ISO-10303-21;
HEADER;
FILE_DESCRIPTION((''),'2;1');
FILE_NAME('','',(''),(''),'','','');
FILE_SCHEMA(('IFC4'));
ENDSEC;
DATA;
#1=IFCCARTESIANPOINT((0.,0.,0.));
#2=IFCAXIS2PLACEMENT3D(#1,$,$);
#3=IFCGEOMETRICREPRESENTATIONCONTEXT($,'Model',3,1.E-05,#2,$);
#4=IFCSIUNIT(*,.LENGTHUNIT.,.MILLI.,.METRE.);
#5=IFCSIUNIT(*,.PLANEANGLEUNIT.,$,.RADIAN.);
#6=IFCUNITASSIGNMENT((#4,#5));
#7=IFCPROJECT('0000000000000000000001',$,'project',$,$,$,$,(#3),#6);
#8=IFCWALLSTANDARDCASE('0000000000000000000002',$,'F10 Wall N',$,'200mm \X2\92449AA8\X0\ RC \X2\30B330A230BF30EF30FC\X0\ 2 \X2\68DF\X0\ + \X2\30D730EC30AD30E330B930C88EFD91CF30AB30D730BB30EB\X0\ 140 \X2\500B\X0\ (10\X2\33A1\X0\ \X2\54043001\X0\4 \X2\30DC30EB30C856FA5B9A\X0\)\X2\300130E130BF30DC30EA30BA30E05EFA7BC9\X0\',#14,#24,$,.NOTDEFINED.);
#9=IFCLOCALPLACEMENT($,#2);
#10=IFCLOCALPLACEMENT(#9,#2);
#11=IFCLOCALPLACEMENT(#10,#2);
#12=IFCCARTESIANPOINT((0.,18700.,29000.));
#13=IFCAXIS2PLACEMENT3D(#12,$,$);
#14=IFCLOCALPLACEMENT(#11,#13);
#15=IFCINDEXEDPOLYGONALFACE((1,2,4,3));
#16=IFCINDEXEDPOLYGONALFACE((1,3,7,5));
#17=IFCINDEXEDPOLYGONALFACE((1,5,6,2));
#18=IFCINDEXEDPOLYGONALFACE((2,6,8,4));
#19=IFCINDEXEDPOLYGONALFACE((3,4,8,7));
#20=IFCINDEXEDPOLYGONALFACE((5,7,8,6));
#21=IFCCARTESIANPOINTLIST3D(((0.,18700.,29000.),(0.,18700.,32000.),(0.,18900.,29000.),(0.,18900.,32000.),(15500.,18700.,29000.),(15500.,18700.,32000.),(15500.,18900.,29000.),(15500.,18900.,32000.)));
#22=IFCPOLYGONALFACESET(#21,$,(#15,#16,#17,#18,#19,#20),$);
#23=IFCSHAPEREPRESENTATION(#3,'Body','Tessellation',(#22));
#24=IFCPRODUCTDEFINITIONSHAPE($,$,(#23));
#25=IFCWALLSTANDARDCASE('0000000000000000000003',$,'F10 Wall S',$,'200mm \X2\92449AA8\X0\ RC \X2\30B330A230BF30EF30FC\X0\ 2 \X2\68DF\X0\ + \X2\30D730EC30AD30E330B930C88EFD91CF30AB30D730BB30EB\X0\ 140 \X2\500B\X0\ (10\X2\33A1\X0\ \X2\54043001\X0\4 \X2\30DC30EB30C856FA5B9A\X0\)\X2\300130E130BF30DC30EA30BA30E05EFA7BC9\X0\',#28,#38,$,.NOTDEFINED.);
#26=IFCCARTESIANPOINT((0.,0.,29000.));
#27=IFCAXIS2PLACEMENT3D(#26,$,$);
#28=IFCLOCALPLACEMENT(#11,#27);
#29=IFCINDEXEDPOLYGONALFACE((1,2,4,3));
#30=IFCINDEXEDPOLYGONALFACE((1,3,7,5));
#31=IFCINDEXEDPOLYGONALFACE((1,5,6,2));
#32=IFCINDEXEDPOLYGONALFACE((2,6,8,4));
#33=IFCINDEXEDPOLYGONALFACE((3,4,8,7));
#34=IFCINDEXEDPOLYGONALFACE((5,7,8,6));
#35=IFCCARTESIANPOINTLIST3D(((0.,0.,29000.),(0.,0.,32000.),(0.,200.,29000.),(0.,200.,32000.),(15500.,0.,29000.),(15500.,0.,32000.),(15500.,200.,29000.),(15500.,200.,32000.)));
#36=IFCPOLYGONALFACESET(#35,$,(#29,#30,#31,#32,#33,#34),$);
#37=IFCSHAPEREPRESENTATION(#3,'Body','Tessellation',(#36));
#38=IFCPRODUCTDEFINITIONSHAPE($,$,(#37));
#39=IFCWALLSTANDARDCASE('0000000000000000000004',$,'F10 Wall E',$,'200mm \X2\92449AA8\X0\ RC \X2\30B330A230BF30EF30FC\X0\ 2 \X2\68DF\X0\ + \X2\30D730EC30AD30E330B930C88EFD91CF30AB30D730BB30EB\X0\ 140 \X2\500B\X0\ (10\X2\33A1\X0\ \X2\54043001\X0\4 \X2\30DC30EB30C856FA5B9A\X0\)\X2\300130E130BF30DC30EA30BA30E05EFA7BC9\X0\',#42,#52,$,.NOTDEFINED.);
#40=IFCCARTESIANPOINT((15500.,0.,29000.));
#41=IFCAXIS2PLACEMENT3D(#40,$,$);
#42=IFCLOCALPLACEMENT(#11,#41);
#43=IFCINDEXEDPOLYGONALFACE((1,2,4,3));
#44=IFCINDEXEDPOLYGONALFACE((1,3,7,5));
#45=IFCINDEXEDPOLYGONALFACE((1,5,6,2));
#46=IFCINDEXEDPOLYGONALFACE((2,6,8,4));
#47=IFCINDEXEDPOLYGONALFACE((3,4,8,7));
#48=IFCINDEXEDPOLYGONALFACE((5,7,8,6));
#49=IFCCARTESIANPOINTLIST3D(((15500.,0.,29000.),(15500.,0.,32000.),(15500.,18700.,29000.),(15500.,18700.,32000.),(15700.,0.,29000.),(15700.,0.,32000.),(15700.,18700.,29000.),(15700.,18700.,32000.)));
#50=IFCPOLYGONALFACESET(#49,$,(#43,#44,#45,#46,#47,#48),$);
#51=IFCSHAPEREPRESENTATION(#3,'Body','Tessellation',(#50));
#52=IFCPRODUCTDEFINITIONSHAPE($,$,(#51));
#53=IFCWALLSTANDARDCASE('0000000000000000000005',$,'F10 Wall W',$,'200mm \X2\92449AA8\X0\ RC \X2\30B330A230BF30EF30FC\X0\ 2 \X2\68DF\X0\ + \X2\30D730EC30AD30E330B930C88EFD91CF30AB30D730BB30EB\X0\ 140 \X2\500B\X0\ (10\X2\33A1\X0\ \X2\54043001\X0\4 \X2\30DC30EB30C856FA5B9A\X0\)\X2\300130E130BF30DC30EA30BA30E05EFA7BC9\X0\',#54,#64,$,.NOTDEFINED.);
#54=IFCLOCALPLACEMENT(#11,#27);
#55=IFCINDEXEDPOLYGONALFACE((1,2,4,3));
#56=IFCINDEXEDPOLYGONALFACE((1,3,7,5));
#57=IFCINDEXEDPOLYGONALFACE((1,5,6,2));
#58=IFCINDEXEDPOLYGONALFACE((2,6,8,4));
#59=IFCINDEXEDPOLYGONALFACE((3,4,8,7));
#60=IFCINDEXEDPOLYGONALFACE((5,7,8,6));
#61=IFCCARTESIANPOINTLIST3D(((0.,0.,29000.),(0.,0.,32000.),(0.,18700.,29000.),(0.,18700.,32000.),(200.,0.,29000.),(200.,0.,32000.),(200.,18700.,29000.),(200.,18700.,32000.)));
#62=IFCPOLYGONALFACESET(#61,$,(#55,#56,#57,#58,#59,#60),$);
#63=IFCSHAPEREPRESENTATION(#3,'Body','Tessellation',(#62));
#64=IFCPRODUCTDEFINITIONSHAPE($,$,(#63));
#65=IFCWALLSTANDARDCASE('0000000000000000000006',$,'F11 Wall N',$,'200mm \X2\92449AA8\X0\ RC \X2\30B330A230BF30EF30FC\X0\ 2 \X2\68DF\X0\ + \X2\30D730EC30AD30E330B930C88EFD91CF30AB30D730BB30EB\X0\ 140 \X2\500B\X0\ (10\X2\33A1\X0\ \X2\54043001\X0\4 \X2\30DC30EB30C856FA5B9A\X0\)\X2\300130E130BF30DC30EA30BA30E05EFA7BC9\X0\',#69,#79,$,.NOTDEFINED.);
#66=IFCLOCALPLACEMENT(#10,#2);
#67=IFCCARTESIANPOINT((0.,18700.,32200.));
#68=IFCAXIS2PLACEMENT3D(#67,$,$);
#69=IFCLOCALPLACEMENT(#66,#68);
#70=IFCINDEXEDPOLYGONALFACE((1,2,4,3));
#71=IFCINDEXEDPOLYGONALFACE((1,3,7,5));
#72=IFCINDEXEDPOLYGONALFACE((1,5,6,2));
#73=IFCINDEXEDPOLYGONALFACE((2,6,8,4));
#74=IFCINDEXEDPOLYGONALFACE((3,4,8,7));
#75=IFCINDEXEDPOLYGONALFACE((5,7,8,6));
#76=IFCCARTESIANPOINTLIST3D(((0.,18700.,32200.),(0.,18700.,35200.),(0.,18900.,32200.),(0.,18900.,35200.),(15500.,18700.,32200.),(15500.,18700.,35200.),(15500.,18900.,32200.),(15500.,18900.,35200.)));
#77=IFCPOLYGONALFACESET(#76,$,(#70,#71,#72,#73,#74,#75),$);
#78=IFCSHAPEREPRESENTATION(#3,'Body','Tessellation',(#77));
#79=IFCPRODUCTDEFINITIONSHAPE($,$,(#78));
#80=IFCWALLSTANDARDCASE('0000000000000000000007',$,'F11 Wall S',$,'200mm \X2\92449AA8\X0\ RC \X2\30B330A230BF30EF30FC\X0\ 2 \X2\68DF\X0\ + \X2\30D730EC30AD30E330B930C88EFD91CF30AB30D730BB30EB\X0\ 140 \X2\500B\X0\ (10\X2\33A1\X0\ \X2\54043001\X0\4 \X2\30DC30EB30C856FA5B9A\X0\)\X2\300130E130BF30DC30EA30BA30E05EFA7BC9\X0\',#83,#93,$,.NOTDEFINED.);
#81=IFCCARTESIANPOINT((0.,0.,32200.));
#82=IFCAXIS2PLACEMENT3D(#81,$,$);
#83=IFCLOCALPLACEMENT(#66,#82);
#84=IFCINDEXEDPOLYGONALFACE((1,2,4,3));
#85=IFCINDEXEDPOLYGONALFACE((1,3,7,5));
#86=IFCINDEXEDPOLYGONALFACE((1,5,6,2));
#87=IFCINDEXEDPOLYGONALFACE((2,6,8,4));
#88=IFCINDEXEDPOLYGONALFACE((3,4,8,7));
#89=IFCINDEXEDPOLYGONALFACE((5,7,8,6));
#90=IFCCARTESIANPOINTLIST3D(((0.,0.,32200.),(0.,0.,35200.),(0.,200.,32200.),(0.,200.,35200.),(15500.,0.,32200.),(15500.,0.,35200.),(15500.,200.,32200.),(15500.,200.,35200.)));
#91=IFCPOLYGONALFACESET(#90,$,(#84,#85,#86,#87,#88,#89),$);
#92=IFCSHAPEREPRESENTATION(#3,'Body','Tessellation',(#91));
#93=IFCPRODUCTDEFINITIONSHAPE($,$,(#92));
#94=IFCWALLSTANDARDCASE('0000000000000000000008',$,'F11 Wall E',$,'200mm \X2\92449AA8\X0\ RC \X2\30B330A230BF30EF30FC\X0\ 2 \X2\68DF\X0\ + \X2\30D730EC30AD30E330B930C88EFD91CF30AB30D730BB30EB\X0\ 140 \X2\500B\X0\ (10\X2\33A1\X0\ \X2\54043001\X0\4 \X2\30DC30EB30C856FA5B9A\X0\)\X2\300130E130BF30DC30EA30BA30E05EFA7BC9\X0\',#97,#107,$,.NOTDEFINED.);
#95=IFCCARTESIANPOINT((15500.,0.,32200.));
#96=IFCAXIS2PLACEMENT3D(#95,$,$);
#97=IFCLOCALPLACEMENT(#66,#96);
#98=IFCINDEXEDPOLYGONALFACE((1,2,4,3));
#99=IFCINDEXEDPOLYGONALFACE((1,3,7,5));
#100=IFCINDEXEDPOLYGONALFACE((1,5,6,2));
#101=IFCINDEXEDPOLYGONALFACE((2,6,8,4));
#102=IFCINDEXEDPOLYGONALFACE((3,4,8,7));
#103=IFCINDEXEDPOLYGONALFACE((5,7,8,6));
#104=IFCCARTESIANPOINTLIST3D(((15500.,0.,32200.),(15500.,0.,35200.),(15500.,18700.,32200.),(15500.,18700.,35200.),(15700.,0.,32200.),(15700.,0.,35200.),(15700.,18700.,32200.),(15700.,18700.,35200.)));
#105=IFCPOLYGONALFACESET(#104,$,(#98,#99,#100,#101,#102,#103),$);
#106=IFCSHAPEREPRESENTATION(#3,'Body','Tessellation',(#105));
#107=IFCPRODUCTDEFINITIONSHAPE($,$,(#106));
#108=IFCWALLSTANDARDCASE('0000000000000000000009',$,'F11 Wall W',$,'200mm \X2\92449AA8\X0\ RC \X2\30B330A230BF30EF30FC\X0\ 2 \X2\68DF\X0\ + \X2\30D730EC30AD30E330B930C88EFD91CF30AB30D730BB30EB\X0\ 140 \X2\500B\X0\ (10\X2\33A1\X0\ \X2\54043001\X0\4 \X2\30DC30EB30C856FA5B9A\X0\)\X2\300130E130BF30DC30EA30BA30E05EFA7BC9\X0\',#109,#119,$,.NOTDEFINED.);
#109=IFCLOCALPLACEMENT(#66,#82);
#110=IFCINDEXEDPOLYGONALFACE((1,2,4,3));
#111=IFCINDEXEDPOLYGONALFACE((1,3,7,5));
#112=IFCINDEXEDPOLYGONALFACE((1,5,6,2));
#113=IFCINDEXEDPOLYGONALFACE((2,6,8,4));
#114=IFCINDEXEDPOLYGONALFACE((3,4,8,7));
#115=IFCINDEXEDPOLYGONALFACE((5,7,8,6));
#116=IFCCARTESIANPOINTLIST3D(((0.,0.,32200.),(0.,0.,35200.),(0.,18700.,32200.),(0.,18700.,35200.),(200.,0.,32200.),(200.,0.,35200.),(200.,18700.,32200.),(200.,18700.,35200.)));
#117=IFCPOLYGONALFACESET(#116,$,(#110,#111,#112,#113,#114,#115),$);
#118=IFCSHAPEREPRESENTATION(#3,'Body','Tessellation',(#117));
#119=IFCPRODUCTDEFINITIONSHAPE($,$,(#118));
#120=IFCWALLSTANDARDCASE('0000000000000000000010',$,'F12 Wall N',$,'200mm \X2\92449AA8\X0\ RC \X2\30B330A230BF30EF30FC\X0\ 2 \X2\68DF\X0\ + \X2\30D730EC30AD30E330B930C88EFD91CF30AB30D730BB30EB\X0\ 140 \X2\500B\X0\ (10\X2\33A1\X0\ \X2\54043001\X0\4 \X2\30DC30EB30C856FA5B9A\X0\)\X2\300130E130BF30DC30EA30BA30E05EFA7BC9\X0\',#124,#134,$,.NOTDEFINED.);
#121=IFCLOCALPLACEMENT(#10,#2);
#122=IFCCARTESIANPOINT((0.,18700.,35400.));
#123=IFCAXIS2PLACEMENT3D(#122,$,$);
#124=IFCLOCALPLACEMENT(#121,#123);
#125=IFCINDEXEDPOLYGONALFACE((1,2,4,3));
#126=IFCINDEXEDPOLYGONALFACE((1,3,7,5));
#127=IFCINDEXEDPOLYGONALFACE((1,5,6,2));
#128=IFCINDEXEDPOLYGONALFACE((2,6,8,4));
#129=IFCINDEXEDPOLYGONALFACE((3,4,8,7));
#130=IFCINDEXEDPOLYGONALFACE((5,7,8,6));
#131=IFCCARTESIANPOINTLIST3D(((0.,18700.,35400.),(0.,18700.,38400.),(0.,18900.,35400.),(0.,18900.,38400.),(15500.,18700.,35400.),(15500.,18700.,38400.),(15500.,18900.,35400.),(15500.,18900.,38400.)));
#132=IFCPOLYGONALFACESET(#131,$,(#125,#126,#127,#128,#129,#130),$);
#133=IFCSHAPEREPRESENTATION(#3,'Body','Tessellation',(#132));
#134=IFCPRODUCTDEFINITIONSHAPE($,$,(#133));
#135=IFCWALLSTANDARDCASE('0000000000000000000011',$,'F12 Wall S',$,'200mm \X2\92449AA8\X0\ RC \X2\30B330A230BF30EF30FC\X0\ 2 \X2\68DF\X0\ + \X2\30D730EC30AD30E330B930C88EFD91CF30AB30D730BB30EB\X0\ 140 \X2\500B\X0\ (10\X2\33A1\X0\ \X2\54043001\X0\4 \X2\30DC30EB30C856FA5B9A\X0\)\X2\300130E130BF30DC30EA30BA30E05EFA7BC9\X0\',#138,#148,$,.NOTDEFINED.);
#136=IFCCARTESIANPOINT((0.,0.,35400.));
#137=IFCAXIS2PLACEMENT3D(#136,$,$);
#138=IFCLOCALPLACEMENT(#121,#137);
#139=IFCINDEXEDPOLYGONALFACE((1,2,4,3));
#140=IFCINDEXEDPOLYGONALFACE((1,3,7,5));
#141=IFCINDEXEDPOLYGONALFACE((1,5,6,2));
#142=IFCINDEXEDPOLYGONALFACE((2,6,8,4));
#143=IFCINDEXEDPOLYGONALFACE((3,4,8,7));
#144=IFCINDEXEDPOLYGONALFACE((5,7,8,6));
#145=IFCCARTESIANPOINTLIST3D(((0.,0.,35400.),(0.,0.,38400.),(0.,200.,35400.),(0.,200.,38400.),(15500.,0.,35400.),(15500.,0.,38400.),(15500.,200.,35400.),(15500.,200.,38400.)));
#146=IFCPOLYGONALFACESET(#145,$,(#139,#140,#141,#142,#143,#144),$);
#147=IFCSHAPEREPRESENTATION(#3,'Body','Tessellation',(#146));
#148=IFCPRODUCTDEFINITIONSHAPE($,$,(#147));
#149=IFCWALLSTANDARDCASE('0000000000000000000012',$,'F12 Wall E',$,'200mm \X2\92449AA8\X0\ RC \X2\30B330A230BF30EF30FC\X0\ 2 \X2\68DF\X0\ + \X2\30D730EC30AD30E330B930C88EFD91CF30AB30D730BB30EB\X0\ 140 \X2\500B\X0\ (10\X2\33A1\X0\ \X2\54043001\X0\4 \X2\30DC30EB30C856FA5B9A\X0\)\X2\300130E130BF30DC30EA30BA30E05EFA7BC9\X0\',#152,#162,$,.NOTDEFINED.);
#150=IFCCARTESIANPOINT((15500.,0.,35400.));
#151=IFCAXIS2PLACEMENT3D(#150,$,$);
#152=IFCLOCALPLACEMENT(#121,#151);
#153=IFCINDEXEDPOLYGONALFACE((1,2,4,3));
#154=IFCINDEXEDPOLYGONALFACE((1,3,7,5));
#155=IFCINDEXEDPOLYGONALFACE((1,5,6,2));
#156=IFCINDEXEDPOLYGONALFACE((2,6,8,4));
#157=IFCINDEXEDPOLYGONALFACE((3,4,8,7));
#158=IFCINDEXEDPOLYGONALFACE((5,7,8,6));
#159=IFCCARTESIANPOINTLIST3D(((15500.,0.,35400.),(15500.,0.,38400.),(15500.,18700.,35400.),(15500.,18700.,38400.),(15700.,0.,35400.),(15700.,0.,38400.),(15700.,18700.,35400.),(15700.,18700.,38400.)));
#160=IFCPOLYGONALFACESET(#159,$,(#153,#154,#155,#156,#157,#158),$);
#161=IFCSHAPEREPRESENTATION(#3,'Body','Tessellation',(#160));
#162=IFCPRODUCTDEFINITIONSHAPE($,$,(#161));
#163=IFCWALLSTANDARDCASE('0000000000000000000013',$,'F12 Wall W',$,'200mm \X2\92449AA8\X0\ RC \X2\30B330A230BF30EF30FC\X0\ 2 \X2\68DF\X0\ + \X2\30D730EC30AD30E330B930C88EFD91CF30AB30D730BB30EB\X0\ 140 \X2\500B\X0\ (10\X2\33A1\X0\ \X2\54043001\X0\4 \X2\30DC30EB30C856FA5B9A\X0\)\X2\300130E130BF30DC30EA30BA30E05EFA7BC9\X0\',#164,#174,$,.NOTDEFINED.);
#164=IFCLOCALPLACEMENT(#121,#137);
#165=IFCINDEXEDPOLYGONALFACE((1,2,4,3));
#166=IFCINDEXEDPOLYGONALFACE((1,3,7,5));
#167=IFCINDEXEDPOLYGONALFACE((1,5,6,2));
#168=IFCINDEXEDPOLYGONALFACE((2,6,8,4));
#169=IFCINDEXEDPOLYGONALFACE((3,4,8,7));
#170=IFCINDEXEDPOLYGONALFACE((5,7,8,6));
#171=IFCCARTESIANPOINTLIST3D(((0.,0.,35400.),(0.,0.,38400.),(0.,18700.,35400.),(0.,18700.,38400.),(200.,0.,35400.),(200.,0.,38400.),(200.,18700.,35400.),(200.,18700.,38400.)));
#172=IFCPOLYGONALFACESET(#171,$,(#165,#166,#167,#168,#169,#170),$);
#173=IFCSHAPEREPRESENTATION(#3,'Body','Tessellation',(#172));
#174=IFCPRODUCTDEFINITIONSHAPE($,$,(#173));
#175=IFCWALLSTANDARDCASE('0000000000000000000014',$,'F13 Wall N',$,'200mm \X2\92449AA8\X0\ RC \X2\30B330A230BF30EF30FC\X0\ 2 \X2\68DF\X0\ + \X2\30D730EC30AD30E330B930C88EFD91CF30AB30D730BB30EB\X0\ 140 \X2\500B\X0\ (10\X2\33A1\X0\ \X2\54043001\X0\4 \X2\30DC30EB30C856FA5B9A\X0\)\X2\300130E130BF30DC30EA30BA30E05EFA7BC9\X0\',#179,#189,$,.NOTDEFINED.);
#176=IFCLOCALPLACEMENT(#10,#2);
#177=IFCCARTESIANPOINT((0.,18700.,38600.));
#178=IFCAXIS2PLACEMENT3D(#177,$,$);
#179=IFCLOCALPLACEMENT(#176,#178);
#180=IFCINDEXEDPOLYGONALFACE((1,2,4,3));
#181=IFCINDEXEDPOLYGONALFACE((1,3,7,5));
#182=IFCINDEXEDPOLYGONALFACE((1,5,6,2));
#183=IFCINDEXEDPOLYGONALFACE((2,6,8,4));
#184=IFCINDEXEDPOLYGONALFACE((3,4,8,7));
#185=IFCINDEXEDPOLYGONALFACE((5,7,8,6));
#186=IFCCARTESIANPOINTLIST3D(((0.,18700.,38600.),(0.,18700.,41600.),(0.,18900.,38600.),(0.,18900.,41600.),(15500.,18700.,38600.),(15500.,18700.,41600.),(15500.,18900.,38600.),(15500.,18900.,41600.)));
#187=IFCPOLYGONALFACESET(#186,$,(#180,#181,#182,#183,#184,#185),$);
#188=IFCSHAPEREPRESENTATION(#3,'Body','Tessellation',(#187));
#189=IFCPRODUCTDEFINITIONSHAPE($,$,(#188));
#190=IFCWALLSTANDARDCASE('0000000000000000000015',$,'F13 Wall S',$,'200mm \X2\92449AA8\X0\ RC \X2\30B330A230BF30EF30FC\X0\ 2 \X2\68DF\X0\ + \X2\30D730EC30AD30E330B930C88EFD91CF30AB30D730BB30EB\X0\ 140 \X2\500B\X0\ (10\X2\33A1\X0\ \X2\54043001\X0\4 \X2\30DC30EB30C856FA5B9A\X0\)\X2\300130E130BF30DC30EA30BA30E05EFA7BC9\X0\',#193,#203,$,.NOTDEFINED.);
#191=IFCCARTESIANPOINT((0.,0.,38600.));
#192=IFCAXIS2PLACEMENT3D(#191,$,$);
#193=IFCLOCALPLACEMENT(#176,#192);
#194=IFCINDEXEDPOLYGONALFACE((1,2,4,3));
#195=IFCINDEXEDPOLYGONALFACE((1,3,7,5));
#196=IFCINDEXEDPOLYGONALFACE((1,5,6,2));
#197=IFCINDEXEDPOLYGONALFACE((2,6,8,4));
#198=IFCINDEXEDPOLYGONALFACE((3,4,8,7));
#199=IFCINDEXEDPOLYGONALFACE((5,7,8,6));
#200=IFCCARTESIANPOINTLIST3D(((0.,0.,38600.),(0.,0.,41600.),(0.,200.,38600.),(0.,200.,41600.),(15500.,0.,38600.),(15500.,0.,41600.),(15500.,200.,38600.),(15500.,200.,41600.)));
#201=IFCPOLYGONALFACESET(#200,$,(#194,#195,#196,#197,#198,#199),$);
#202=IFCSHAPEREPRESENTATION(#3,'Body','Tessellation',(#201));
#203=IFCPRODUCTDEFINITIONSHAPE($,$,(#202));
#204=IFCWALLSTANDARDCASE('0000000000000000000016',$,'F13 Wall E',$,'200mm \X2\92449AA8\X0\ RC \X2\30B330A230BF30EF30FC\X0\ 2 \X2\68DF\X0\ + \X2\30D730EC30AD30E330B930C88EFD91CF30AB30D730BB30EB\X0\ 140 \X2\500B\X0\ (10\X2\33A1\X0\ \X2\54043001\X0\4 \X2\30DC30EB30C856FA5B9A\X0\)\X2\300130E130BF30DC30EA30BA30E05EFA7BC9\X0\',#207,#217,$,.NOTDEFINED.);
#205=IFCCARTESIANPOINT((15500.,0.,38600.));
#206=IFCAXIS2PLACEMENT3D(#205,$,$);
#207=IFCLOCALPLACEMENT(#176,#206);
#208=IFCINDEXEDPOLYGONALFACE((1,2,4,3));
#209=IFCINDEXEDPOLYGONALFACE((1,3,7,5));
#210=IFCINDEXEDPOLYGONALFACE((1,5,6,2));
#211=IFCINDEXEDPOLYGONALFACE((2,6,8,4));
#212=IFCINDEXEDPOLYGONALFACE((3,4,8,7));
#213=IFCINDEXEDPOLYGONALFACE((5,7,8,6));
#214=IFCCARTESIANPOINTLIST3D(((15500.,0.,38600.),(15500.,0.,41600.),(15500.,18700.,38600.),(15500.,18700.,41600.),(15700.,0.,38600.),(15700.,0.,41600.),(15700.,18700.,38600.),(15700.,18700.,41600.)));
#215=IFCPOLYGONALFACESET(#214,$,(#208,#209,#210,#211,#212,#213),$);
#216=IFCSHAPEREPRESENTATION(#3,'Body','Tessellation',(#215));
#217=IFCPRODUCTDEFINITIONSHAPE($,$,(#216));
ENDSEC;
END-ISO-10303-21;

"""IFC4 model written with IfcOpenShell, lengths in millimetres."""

from ifc_helpers import new_model, si_unit, frame, frame_2d, origin, place, context, project, rectangle, extrude, element, save


model = new_model("IFC4")

# Units and contexts
model_context = context("Model", 3, precision=1e-05, world=origin())
ifc_project = project(units=[si_unit("LENGTHUNIT", "METRE", prefix="MILLI"), si_unit("PLANEANGLEUNIT", "RADIAN")], contexts=[model_context])

# Shared definitions
placement_1 = place(None, origin())
placement_2 = place(placement_1, origin())
placement_3 = place(placement_2, origin())
placement_4 = place(placement_2, origin())
placement_5 = place(placement_2, origin())
placement_6 = place(placement_2, origin())

# Walls
wall_1_placement = place(placement_3, frame((0.0, 18700.0, 29000.0)))
element("IfcWallStandardCase", 1, at=wall_1_placement, Name="F10 Wall N", ObjectType="200mm 鉄骨 RC コアタワー 2 棟 + プレキャスト軽量カプセル 140 個 (10㎡ 各、4 ボルト固定)、メタボリズム建築", PredefinedType="NOTDEFINED", context=model_context, shape_type="SweptSolid", body=[
    extrude(rectangle(XDim=15500.0, YDim=200.0, at=frame_2d((7750.0, 100.0))), frame((0.0, 18700.0, 29000.0)), (0.0, 0.0, 1.0), 3000.0),
])
wall_2_placement = place(placement_3, frame((0.0, 0.0, 29000.0)))
element("IfcWallStandardCase", 2, at=wall_2_placement, Name="F10 Wall S", ObjectType="200mm 鉄骨 RC コアタワー 2 棟 + プレキャスト軽量カプセル 140 個 (10㎡ 各、4 ボルト固定)、メタボリズム建築", PredefinedType="NOTDEFINED", context=model_context, shape_type="SweptSolid", body=[
    extrude(rectangle(XDim=15500.0, YDim=200.0, at=frame_2d((7750.0, 100.0))), frame((0.0, 0.0, 29000.0)), (0.0, 0.0, 1.0), 3000.0),
])
wall_3_placement = place(placement_3, frame((15500.0, 0.0, 29000.0)))
element("IfcWallStandardCase", 3, at=wall_3_placement, Name="F10 Wall E", ObjectType="200mm 鉄骨 RC コアタワー 2 棟 + プレキャスト軽量カプセル 140 個 (10㎡ 各、4 ボルト固定)、メタボリズム建築", PredefinedType="NOTDEFINED", context=model_context, shape_type="SweptSolid", body=[
    extrude(rectangle(XDim=200.0, YDim=18700.0, at=frame_2d((100.0, 9350.0))), frame((15500.0, 0.0, 29000.0)), (0.0, 0.0, 1.0), 3000.0),
])
wall_4_placement = place(placement_3, frame((0.0, 0.0, 29000.0)))
element("IfcWallStandardCase", 4, at=wall_4_placement, Name="F10 Wall W", ObjectType="200mm 鉄骨 RC コアタワー 2 棟 + プレキャスト軽量カプセル 140 個 (10㎡ 各、4 ボルト固定)、メタボリズム建築", PredefinedType="NOTDEFINED", context=model_context, shape_type="SweptSolid", body=[
    extrude(rectangle(XDim=200.0, YDim=18700.0, at=frame_2d((100.0, 9350.0))), frame((0.0, 0.0, 29000.0)), (0.0, 0.0, 1.0), 3000.0),
])
wall_5_placement = place(placement_4, frame((0.0, 18700.0, 32200.0)))
element("IfcWallStandardCase", 5, at=wall_5_placement, Name="F11 Wall N", ObjectType="200mm 鉄骨 RC コアタワー 2 棟 + プレキャスト軽量カプセル 140 個 (10㎡ 各、4 ボルト固定)、メタボリズム建築", PredefinedType="NOTDEFINED", context=model_context, shape_type="SweptSolid", body=[
    extrude(rectangle(XDim=15500.0, YDim=200.0, at=frame_2d((7750.0, 100.0))), frame((0.0, 18700.0, 32200.0)), (0.0, 0.0, 1.0), 3000.0),
])
wall_6_placement = place(placement_4, frame((0.0, 0.0, 32200.0)))
element("IfcWallStandardCase", 6, at=wall_6_placement, Name="F11 Wall S", ObjectType="200mm 鉄骨 RC コアタワー 2 棟 + プレキャスト軽量カプセル 140 個 (10㎡ 各、4 ボルト固定)、メタボリズム建築", PredefinedType="NOTDEFINED", context=model_context, shape_type="SweptSolid", body=[
    extrude(rectangle(XDim=15500.0, YDim=200.0, at=frame_2d((7750.0, 100.0))), frame((0.0, 0.0, 32200.0)), (0.0, 0.0, 1.0), 3000.0),
])
wall_7_placement = place(placement_4, frame((15500.0, 0.0, 32200.0)))
element("IfcWallStandardCase", 7, at=wall_7_placement, Name="F11 Wall E", ObjectType="200mm 鉄骨 RC コアタワー 2 棟 + プレキャスト軽量カプセル 140 個 (10㎡ 各、4 ボルト固定)、メタボリズム建築", PredefinedType="NOTDEFINED", context=model_context, shape_type="SweptSolid", body=[
    extrude(rectangle(XDim=200.0, YDim=18700.0, at=frame_2d((100.0, 9350.0))), frame((15500.0, 0.0, 32200.0)), (0.0, 0.0, 1.0), 3000.0),
])
wall_8_placement = place(placement_4, frame((0.0, 0.0, 32200.0)))
element("IfcWallStandardCase", 8, at=wall_8_placement, Name="F11 Wall W", ObjectType="200mm 鉄骨 RC コアタワー 2 棟 + プレキャスト軽量カプセル 140 個 (10㎡ 各、4 ボルト固定)、メタボリズム建築", PredefinedType="NOTDEFINED", context=model_context, shape_type="SweptSolid", body=[
    extrude(rectangle(XDim=200.0, YDim=18700.0, at=frame_2d((100.0, 9350.0))), frame((0.0, 0.0, 32200.0)), (0.0, 0.0, 1.0), 3000.0),
])
wall_9_placement = place(placement_5, frame((0.0, 18700.0, 35400.0)))
element("IfcWallStandardCase", 9, at=wall_9_placement, Name="F12 Wall N", ObjectType="200mm 鉄骨 RC コアタワー 2 棟 + プレキャスト軽量カプセル 140 個 (10㎡ 各、4 ボルト固定)、メタボリズム建築", PredefinedType="NOTDEFINED", context=model_context, shape_type="SweptSolid", body=[
    extrude(rectangle(XDim=15500.0, YDim=200.0, at=frame_2d((7750.0, 100.0))), frame((0.0, 18700.0, 35400.0)), (0.0, 0.0, 1.0), 3000.0),
])
wall_10_placement = place(placement_5, frame((0.0, 0.0, 35400.0)))
element("IfcWallStandardCase", 10, at=wall_10_placement, Name="F12 Wall S", ObjectType="200mm 鉄骨 RC コアタワー 2 棟 + プレキャスト軽量カプセル 140 個 (10㎡ 各、4 ボルト固定)、メタボリズム建築", PredefinedType="NOTDEFINED", context=model_context, shape_type="SweptSolid", body=[
    extrude(rectangle(XDim=15500.0, YDim=200.0, at=frame_2d((7750.0, 100.0))), frame((0.0, 0.0, 35400.0)), (0.0, 0.0, 1.0), 3000.0),
])
wall_11_placement = place(placement_5, frame((15500.0, 0.0, 35400.0)))
element("IfcWallStandardCase", 11, at=wall_11_placement, Name="F12 Wall E", ObjectType="200mm 鉄骨 RC コアタワー 2 棟 + プレキャスト軽量カプセル 140 個 (10㎡ 各、4 ボルト固定)、メタボリズム建築", PredefinedType="NOTDEFINED", context=model_context, shape_type="SweptSolid", body=[
    extrude(rectangle(XDim=200.0, YDim=18700.0, at=frame_2d((100.0, 9350.0))), frame((15500.0, 0.0, 35400.0)), (0.0, 0.0, 1.0), 3000.0),
])
wall_12_placement = place(placement_5, frame((0.0, 0.0, 35400.0)))
element("IfcWallStandardCase", 12, at=wall_12_placement, Name="F12 Wall W", ObjectType="200mm 鉄骨 RC コアタワー 2 棟 + プレキャスト軽量カプセル 140 個 (10㎡ 各、4 ボルト固定)、メタボリズム建築", PredefinedType="NOTDEFINED", context=model_context, shape_type="SweptSolid", body=[
    extrude(rectangle(XDim=200.0, YDim=18700.0, at=frame_2d((100.0, 9350.0))), frame((0.0, 0.0, 35400.0)), (0.0, 0.0, 1.0), 3000.0),
])
wall_13_placement = place(placement_6, frame((0.0, 18700.0, 38600.0)))
element("IfcWallStandardCase", 13, at=wall_13_placement, Name="F13 Wall N", ObjectType="200mm 鉄骨 RC コアタワー 2 棟 + プレキャスト軽量カプセル 140 個 (10㎡ 各、4 ボルト固定)、メタボリズム建築", PredefinedType="NOTDEFINED", context=model_context, shape_type="SweptSolid", body=[
    extrude(rectangle(XDim=15500.0, YDim=200.0, at=frame_2d((7750.0, 100.0))), frame((0.0, 18700.0, 38600.0)), (0.0, 0.0, 1.0), 3000.0),
])
wall_14_placement = place(placement_6, frame((0.0, 0.0, 38600.0)))
element("IfcWallStandardCase", 14, at=wall_14_placement, Name="F13 Wall S", ObjectType="200mm 鉄骨 RC コアタワー 2 棟 + プレキャスト軽量カプセル 140 個 (10㎡ 各、4 ボルト固定)、メタボリズム建築", PredefinedType="NOTDEFINED", context=model_context, shape_type="SweptSolid", body=[
    extrude(rectangle(XDim=15500.0, YDim=200.0, at=frame_2d((7750.0, 100.0))), frame((0.0, 0.0, 38600.0)), (0.0, 0.0, 1.0), 3000.0),
])
wall_15_placement = place(placement_6, frame((15500.0, 0.0, 38600.0)))
element("IfcWallStandardCase", 15, at=wall_15_placement, Name="F13 Wall E", ObjectType="200mm 鉄骨 RC コアタワー 2 棟 + プレキャスト軽量カプセル 140 個 (10㎡ 各、4 ボルト固定)、メタボリズム建築", PredefinedType="NOTDEFINED", context=model_context, shape_type="SweptSolid", body=[
    extrude(rectangle(XDim=200.0, YDim=18700.0, at=frame_2d((100.0, 9350.0))), frame((15500.0, 0.0, 38600.0)), (0.0, 0.0, 1.0), 3000.0),
])

save(model, "model.ifc")
